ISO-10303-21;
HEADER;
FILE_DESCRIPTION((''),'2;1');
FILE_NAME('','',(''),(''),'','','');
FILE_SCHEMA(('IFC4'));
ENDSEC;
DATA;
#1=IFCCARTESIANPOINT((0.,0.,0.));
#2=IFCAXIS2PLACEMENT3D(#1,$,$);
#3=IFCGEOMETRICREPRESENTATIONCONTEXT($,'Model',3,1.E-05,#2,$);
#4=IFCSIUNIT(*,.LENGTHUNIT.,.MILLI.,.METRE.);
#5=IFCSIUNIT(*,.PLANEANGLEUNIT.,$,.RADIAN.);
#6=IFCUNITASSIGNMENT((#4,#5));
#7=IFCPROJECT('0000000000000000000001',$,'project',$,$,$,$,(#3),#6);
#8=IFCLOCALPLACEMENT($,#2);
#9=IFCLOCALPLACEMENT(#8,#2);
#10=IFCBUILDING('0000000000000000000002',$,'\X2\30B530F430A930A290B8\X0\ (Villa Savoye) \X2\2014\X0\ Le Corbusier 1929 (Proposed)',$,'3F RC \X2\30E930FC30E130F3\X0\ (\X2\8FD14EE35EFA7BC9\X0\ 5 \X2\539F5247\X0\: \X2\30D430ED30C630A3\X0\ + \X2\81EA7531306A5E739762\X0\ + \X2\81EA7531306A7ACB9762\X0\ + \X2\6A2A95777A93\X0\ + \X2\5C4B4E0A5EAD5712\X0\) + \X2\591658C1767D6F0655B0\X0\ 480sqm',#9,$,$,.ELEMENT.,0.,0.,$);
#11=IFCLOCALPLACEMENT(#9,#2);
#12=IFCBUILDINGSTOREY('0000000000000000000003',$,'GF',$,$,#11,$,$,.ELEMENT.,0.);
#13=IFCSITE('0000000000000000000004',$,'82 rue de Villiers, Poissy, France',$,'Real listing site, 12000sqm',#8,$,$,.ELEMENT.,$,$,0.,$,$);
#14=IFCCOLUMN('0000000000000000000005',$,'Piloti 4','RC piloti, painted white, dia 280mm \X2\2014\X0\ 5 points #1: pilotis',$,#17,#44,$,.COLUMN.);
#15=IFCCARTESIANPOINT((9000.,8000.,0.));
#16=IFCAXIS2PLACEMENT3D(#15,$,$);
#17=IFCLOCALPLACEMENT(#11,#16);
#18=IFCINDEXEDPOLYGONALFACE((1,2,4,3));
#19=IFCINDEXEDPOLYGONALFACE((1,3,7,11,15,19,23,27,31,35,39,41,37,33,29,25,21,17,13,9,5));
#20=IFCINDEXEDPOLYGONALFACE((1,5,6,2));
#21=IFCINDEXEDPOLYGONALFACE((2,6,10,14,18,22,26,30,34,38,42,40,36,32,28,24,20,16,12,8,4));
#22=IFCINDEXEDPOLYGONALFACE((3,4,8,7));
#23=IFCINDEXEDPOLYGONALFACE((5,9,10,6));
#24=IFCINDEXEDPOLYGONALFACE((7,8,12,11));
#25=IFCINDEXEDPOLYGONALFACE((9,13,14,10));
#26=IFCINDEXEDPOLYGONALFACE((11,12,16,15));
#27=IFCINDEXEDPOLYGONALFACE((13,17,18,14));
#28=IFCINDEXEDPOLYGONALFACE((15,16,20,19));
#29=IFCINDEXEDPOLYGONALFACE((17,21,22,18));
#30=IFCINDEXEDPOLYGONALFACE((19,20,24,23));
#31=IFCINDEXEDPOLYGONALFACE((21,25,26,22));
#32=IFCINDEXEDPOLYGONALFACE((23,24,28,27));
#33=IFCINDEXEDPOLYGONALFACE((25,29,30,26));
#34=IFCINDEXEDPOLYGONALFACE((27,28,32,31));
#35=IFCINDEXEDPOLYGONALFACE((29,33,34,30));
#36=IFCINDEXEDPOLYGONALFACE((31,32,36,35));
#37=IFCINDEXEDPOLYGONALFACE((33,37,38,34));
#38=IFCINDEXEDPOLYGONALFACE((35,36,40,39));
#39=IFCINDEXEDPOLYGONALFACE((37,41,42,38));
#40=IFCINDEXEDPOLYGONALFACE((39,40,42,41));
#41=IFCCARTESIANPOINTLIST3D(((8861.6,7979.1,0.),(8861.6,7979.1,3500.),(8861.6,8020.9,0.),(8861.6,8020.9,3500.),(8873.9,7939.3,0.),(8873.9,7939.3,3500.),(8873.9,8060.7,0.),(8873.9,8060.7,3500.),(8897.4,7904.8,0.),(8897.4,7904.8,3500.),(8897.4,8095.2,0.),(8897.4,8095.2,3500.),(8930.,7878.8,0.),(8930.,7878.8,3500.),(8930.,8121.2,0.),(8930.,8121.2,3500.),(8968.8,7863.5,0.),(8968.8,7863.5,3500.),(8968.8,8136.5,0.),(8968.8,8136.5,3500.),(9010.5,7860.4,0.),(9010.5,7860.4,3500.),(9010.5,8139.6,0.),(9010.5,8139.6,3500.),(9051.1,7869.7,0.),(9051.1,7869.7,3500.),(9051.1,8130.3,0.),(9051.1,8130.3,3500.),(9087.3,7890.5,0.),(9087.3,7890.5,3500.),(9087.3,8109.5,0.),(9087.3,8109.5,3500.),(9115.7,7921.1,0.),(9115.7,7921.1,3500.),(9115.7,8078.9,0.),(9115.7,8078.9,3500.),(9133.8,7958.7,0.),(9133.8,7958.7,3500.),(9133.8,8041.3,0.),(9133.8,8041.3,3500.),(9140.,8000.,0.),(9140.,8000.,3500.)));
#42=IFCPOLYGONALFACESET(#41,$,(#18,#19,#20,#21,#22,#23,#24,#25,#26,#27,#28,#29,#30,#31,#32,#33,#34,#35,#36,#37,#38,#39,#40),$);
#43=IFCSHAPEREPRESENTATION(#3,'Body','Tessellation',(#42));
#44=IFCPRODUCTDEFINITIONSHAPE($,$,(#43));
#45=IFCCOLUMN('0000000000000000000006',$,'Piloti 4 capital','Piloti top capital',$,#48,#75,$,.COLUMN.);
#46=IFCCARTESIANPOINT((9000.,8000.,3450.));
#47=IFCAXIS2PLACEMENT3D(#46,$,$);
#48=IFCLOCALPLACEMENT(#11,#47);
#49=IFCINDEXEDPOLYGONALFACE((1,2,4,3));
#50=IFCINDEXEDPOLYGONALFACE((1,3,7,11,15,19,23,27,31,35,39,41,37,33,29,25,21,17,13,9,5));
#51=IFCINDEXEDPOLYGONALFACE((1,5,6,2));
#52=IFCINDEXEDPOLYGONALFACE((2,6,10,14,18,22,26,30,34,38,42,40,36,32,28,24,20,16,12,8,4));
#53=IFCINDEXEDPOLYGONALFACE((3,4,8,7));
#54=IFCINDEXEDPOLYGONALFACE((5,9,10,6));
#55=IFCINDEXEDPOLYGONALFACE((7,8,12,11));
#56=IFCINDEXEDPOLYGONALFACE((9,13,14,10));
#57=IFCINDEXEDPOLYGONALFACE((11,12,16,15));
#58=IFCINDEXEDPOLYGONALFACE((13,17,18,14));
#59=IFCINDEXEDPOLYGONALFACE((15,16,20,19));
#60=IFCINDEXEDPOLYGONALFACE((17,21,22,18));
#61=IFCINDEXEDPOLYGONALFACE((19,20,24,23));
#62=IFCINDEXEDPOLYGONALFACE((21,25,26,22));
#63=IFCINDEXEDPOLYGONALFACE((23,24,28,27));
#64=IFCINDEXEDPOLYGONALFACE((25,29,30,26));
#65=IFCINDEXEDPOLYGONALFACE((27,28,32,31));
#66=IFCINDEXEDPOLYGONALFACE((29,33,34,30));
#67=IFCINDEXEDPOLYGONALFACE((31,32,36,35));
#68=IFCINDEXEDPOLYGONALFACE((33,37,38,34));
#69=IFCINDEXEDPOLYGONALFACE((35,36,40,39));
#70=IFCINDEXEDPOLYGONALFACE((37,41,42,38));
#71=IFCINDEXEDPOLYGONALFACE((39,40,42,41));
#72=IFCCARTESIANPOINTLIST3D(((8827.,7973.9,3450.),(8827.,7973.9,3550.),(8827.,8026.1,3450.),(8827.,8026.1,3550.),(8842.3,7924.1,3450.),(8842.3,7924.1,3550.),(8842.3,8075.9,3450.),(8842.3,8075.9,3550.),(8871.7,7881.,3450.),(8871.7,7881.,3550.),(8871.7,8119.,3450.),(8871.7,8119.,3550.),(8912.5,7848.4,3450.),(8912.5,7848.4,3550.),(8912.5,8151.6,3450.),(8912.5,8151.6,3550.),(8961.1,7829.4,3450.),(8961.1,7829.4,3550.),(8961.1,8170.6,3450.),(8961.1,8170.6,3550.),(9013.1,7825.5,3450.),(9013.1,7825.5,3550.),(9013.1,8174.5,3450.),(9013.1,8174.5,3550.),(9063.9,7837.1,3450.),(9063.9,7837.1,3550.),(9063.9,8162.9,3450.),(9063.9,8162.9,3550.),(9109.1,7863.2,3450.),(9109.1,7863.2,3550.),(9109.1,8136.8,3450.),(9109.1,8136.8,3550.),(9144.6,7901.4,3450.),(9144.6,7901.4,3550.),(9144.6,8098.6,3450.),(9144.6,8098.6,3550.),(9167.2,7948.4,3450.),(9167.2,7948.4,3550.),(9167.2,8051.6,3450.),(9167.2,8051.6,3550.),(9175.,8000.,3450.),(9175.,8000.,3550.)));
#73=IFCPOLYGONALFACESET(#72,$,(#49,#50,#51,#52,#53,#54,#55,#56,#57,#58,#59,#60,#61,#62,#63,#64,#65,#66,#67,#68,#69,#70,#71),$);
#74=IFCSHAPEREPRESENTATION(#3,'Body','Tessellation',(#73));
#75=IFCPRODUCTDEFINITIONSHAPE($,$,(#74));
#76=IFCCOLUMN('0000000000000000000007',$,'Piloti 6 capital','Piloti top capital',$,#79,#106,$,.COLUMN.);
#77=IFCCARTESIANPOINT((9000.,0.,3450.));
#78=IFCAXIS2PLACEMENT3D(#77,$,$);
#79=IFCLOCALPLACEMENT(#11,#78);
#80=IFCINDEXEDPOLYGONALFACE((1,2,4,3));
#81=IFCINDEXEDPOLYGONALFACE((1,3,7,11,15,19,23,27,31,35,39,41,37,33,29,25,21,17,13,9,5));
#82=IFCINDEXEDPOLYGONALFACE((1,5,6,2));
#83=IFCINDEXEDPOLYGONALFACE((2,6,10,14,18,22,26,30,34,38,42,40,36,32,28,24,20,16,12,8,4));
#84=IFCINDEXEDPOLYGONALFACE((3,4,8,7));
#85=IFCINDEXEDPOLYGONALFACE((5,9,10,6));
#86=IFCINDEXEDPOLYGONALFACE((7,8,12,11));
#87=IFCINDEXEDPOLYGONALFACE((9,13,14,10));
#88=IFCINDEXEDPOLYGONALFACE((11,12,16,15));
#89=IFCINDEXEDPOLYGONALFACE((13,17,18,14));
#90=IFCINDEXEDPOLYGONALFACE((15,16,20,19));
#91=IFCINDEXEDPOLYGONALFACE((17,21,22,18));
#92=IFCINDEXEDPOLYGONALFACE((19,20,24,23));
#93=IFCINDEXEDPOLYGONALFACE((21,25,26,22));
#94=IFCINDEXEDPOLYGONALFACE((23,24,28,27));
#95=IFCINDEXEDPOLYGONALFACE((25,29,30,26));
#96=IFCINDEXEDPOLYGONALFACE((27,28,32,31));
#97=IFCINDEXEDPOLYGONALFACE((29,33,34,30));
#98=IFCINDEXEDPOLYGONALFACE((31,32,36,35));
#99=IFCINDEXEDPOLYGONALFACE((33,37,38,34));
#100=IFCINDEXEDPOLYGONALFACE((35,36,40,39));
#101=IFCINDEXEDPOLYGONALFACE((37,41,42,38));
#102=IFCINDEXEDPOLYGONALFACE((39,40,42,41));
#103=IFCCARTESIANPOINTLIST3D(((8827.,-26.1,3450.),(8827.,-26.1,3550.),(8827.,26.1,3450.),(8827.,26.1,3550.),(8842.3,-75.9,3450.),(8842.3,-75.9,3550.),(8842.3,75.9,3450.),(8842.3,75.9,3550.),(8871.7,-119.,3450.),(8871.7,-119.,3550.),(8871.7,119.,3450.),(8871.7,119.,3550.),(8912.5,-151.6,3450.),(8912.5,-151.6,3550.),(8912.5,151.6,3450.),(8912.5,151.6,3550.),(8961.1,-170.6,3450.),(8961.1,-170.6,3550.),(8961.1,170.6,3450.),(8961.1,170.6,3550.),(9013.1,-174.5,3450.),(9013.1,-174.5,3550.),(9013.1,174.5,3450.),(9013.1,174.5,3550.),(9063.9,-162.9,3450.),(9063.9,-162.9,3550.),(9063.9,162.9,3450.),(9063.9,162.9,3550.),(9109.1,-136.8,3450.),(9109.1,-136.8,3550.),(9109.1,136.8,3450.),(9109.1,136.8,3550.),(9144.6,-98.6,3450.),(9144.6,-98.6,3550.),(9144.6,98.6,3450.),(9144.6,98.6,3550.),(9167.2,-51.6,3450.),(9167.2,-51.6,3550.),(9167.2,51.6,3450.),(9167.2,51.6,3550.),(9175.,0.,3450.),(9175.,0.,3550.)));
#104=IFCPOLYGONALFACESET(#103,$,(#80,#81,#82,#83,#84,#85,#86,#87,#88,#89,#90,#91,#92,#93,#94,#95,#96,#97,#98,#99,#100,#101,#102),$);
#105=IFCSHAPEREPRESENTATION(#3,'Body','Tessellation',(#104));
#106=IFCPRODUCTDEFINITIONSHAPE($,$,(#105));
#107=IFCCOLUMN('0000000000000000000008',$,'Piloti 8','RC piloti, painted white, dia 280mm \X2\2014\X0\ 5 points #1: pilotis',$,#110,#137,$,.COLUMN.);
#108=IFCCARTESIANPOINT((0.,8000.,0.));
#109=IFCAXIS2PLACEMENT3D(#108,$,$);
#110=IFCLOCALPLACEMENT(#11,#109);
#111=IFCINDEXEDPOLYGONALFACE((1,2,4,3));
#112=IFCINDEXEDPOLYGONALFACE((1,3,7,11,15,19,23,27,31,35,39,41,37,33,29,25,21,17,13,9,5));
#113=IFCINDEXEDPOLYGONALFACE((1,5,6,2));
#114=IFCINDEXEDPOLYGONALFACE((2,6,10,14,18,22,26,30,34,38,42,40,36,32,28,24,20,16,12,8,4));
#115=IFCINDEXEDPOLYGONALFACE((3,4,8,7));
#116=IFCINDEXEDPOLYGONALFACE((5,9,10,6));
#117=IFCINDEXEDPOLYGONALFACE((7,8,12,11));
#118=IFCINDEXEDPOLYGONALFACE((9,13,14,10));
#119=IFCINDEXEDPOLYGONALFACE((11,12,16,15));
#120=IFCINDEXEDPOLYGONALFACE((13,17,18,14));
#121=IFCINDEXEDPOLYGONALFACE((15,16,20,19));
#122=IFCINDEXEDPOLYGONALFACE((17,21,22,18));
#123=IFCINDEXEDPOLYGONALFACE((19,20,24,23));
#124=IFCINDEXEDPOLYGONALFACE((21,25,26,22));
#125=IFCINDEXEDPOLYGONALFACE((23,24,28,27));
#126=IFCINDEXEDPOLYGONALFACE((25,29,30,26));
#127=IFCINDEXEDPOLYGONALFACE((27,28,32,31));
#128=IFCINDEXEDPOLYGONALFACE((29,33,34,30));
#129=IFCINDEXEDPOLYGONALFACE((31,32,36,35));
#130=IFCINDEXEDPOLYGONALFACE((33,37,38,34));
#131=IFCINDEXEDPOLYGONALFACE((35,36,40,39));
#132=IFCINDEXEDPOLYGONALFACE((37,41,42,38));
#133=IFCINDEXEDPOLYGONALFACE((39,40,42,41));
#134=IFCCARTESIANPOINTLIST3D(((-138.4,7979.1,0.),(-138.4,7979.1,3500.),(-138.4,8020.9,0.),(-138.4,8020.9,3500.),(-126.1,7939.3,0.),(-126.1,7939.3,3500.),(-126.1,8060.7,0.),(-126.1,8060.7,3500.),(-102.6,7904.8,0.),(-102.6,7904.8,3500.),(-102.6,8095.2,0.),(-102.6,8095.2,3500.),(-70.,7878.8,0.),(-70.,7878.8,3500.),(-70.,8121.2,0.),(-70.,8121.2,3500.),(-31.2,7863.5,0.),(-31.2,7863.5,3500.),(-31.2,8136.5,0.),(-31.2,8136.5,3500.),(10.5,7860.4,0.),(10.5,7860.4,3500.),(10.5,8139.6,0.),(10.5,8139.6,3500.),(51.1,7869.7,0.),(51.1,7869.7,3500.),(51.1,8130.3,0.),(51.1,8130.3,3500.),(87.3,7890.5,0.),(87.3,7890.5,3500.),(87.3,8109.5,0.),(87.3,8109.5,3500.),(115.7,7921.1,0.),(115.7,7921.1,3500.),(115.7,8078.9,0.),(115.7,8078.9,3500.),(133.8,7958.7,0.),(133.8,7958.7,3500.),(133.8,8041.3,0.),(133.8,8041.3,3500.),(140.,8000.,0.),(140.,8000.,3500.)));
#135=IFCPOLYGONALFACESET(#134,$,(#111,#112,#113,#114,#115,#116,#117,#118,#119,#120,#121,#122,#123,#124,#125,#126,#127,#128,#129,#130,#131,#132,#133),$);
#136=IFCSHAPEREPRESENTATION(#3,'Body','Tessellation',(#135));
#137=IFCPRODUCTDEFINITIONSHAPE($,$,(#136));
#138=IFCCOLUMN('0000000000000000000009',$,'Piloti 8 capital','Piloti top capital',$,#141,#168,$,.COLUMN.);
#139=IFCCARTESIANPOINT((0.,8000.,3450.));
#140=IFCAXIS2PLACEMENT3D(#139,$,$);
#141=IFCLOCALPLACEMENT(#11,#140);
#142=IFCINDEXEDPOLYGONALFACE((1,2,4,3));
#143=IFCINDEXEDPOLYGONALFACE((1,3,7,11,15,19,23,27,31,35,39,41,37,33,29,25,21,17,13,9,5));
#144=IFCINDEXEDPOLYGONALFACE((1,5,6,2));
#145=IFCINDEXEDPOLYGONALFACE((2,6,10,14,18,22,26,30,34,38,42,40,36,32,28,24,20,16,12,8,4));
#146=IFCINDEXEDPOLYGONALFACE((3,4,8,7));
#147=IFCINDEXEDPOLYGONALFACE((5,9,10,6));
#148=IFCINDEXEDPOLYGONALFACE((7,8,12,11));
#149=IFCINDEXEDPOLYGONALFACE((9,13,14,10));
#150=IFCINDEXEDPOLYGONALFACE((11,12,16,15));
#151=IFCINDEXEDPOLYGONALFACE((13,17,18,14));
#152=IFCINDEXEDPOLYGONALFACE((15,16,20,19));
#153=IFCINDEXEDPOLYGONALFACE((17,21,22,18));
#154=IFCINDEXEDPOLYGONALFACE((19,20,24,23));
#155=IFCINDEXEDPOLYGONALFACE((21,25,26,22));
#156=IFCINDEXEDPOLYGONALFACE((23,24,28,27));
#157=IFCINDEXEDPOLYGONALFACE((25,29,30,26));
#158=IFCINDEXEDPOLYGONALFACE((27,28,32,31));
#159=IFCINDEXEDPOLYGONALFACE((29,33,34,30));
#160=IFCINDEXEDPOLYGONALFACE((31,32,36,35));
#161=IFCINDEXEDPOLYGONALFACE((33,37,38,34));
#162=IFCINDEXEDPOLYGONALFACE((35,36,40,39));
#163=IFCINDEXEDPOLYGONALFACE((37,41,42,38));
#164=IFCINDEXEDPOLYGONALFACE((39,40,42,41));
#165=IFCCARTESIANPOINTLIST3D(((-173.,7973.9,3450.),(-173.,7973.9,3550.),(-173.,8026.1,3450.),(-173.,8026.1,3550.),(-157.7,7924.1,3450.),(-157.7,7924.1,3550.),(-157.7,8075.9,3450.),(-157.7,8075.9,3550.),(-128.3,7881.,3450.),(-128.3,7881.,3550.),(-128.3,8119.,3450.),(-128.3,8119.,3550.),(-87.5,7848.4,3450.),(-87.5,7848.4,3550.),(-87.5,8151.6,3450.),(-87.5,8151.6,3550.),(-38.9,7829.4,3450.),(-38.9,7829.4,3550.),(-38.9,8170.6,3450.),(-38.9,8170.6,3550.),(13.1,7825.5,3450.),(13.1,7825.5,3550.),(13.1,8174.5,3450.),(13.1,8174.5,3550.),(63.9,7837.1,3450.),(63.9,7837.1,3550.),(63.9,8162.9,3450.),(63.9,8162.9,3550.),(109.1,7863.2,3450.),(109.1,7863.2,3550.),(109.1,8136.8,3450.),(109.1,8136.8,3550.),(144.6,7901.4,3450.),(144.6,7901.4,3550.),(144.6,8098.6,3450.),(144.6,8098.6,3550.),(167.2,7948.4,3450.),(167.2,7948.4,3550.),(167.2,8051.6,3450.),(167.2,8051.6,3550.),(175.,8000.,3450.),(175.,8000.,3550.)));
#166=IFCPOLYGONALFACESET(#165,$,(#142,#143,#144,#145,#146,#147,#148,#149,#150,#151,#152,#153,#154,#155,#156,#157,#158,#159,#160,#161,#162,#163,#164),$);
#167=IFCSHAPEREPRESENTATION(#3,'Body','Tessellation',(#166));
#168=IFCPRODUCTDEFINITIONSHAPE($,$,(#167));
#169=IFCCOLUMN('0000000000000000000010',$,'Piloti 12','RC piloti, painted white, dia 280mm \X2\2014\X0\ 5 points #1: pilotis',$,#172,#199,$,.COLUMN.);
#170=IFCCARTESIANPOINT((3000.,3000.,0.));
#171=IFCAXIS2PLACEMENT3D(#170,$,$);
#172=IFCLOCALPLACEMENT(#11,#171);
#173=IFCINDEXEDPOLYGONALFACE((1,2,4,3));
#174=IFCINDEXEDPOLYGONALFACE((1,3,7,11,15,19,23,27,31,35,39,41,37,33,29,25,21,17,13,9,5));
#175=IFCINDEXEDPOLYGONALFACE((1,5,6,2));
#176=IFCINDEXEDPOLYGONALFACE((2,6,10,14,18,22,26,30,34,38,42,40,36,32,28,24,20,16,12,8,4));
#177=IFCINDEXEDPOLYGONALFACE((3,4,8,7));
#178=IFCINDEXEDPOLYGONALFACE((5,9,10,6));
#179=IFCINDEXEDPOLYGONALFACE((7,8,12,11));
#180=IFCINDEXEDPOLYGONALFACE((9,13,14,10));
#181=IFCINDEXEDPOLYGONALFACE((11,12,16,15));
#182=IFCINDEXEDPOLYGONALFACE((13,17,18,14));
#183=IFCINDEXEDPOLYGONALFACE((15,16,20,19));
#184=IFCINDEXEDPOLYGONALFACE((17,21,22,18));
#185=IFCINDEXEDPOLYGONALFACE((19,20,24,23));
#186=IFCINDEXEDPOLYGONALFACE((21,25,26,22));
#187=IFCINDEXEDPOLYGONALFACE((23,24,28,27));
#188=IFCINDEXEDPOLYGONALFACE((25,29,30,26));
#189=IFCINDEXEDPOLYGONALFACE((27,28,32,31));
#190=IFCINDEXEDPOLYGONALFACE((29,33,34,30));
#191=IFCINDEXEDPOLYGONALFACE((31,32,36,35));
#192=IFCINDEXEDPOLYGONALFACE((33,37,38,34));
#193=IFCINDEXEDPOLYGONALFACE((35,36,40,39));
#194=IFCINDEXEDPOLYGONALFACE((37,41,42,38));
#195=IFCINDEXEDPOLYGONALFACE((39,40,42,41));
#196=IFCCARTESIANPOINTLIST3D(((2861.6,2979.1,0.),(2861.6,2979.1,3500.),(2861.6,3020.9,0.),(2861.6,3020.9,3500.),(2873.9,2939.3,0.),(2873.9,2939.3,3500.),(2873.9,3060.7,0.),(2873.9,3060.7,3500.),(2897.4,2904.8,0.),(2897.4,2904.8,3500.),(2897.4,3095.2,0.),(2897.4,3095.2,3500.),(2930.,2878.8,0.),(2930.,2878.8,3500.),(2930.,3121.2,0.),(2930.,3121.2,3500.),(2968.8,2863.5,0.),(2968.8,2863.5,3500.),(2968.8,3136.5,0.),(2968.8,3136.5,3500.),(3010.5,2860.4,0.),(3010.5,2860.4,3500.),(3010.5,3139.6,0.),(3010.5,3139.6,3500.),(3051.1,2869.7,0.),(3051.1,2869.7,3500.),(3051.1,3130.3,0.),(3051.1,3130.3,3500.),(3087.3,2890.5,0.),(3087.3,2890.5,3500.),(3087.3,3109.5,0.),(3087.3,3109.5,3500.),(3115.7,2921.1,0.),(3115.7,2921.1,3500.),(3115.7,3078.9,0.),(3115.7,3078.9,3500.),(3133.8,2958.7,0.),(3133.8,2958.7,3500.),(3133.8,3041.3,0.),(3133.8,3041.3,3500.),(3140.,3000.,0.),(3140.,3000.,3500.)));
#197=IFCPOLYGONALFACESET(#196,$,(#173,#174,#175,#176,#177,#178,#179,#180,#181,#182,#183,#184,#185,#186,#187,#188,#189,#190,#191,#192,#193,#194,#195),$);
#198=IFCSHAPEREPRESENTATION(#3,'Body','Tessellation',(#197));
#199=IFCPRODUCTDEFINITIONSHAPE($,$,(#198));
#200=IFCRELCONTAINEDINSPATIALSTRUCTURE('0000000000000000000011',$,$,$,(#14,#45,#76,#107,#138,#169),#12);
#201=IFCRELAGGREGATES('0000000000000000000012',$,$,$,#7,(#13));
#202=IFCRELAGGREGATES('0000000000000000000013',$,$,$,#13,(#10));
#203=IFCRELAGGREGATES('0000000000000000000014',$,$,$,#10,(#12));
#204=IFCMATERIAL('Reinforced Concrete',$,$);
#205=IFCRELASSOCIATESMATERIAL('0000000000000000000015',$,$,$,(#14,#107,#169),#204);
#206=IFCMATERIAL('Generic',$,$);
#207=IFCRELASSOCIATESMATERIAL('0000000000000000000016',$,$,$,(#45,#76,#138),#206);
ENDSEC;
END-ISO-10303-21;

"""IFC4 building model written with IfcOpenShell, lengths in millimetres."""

from ifc_helpers import new_model, si_unit, frame, origin, origin_2d, place, context, project, spatial, circle, extrude, material, element, save


model = new_model("IFC4")

# Units and contexts
model_context = context("Model", 3, precision=1e-05, world=origin())
ifc_project = project(units=[si_unit("LENGTHUNIT", "METRE", prefix="MILLI"), si_unit("PLANEANGLEUNIT", "RADIAN")], contexts=[model_context])

# Site, building, storey
site_placement = place(None, origin())
site = spatial("IfcSite", under=ifc_project, at=site_placement, Name="82 rue de Villiers, Poissy, France", ObjectType="Real listing site, 12000sqm", CompositionType="ELEMENT", RefElevation=0.0)
building_placement = place(site_placement, origin())
building = spatial("IfcBuilding", under=site, at=building_placement, Name="サヴォア邸 (Villa Savoye) — Le Corbusier 1929 (Proposed)", ObjectType="3F RC ラーメン (近代建築 5 原則: ピロティ + 自由な平面 + 自由な立面 + 横長窓 + 屋上庭園) + 外壁白漆喰 480sqm", CompositionType="ELEMENT", ElevationOfRefHeight=0.0, ElevationOfTerrain=0.0)
storey_placement = place(building_placement, origin())
storey = spatial("IfcBuildingStorey", under=building, at=storey_placement, Name="GF", CompositionType="ELEMENT", Elevation=0.0)

# Columns
ifc_material_1 = material(Name="Reinforced Concrete")
column_1_placement = place(storey_placement, frame((9000.0, 8000.0, 0.0)))
element("IfcColumn", 1, at=column_1_placement, inside=storey, material=ifc_material_1, Name="Piloti 4", Description="RC piloti, painted white, dia 280mm — 5 points #1: pilotis", PredefinedType="COLUMN", context=model_context, shape_type="SweptSolid", body=[
    extrude(circle(Radius=140.0, at=origin_2d()), frame((9000.0, 8000.0, 0.0)), (0.0, 0.0, 1.0), 3500.0),
])
ifc_material_2 = material(Name="Generic")
column_2_placement = place(storey_placement, frame((9000.0, 8000.0, 3450.0)))
element("IfcColumn", 2, at=column_2_placement, inside=storey, material=ifc_material_2, Name="Piloti 4 capital", Description="Piloti top capital", PredefinedType="COLUMN", context=model_context, shape_type="SweptSolid", body=[
    extrude(circle(Radius=175.0, at=origin_2d()), frame((9000.0, 8000.0, 3450.0)), (0.0, 0.0, 1.0), 100.0),
])
column_3_placement = place(storey_placement, frame((9000.0, 0.0, 3450.0)))
element("IfcColumn", 3, at=column_3_placement, inside=storey, material=ifc_material_2, Name="Piloti 6 capital", Description="Piloti top capital", PredefinedType="COLUMN", context=model_context, shape_type="SweptSolid", body=[
    extrude(circle(Radius=175.0, at=origin_2d()), frame((9000.0, 0.0, 3450.0)), (0.0, 0.0, 1.0), 100.0),
])
column_4_placement = place(storey_placement, frame((0.0, 8000.0, 0.0)))
element("IfcColumn", 4, at=column_4_placement, inside=storey, material=ifc_material_1, Name="Piloti 8", Description="RC piloti, painted white, dia 280mm — 5 points #1: pilotis", PredefinedType="COLUMN", context=model_context, shape_type="SweptSolid", body=[
    extrude(circle(Radius=140.0, at=origin_2d()), frame((0.0, 8000.0, 0.0)), (0.0, 0.0, 1.0), 3500.0),
])
column_5_placement = place(storey_placement, frame((0.0, 8000.0, 3450.0)))
element("IfcColumn", 5, at=column_5_placement, inside=storey, material=ifc_material_2, Name="Piloti 8 capital", Description="Piloti top capital", PredefinedType="COLUMN", context=model_context, shape_type="SweptSolid", body=[
    extrude(circle(Radius=175.0, at=origin_2d()), frame((0.0, 8000.0, 3450.0)), (0.0, 0.0, 1.0), 100.0),
])
column_6_placement = place(storey_placement, frame((3000.0, 3000.0, 0.0)))
element("IfcColumn", 6, at=column_6_placement, inside=storey, material=ifc_material_1, Name="Piloti 12", Description="RC piloti, painted white, dia 280mm — 5 points #1: pilotis", PredefinedType="COLUMN", context=model_context, shape_type="SweptSolid", body=[
    extrude(circle(Radius=140.0, at=origin_2d()), frame((3000.0, 3000.0, 0.0)), (0.0, 0.0, 1.0), 3500.0),
])

save(model, "model.ifc")
